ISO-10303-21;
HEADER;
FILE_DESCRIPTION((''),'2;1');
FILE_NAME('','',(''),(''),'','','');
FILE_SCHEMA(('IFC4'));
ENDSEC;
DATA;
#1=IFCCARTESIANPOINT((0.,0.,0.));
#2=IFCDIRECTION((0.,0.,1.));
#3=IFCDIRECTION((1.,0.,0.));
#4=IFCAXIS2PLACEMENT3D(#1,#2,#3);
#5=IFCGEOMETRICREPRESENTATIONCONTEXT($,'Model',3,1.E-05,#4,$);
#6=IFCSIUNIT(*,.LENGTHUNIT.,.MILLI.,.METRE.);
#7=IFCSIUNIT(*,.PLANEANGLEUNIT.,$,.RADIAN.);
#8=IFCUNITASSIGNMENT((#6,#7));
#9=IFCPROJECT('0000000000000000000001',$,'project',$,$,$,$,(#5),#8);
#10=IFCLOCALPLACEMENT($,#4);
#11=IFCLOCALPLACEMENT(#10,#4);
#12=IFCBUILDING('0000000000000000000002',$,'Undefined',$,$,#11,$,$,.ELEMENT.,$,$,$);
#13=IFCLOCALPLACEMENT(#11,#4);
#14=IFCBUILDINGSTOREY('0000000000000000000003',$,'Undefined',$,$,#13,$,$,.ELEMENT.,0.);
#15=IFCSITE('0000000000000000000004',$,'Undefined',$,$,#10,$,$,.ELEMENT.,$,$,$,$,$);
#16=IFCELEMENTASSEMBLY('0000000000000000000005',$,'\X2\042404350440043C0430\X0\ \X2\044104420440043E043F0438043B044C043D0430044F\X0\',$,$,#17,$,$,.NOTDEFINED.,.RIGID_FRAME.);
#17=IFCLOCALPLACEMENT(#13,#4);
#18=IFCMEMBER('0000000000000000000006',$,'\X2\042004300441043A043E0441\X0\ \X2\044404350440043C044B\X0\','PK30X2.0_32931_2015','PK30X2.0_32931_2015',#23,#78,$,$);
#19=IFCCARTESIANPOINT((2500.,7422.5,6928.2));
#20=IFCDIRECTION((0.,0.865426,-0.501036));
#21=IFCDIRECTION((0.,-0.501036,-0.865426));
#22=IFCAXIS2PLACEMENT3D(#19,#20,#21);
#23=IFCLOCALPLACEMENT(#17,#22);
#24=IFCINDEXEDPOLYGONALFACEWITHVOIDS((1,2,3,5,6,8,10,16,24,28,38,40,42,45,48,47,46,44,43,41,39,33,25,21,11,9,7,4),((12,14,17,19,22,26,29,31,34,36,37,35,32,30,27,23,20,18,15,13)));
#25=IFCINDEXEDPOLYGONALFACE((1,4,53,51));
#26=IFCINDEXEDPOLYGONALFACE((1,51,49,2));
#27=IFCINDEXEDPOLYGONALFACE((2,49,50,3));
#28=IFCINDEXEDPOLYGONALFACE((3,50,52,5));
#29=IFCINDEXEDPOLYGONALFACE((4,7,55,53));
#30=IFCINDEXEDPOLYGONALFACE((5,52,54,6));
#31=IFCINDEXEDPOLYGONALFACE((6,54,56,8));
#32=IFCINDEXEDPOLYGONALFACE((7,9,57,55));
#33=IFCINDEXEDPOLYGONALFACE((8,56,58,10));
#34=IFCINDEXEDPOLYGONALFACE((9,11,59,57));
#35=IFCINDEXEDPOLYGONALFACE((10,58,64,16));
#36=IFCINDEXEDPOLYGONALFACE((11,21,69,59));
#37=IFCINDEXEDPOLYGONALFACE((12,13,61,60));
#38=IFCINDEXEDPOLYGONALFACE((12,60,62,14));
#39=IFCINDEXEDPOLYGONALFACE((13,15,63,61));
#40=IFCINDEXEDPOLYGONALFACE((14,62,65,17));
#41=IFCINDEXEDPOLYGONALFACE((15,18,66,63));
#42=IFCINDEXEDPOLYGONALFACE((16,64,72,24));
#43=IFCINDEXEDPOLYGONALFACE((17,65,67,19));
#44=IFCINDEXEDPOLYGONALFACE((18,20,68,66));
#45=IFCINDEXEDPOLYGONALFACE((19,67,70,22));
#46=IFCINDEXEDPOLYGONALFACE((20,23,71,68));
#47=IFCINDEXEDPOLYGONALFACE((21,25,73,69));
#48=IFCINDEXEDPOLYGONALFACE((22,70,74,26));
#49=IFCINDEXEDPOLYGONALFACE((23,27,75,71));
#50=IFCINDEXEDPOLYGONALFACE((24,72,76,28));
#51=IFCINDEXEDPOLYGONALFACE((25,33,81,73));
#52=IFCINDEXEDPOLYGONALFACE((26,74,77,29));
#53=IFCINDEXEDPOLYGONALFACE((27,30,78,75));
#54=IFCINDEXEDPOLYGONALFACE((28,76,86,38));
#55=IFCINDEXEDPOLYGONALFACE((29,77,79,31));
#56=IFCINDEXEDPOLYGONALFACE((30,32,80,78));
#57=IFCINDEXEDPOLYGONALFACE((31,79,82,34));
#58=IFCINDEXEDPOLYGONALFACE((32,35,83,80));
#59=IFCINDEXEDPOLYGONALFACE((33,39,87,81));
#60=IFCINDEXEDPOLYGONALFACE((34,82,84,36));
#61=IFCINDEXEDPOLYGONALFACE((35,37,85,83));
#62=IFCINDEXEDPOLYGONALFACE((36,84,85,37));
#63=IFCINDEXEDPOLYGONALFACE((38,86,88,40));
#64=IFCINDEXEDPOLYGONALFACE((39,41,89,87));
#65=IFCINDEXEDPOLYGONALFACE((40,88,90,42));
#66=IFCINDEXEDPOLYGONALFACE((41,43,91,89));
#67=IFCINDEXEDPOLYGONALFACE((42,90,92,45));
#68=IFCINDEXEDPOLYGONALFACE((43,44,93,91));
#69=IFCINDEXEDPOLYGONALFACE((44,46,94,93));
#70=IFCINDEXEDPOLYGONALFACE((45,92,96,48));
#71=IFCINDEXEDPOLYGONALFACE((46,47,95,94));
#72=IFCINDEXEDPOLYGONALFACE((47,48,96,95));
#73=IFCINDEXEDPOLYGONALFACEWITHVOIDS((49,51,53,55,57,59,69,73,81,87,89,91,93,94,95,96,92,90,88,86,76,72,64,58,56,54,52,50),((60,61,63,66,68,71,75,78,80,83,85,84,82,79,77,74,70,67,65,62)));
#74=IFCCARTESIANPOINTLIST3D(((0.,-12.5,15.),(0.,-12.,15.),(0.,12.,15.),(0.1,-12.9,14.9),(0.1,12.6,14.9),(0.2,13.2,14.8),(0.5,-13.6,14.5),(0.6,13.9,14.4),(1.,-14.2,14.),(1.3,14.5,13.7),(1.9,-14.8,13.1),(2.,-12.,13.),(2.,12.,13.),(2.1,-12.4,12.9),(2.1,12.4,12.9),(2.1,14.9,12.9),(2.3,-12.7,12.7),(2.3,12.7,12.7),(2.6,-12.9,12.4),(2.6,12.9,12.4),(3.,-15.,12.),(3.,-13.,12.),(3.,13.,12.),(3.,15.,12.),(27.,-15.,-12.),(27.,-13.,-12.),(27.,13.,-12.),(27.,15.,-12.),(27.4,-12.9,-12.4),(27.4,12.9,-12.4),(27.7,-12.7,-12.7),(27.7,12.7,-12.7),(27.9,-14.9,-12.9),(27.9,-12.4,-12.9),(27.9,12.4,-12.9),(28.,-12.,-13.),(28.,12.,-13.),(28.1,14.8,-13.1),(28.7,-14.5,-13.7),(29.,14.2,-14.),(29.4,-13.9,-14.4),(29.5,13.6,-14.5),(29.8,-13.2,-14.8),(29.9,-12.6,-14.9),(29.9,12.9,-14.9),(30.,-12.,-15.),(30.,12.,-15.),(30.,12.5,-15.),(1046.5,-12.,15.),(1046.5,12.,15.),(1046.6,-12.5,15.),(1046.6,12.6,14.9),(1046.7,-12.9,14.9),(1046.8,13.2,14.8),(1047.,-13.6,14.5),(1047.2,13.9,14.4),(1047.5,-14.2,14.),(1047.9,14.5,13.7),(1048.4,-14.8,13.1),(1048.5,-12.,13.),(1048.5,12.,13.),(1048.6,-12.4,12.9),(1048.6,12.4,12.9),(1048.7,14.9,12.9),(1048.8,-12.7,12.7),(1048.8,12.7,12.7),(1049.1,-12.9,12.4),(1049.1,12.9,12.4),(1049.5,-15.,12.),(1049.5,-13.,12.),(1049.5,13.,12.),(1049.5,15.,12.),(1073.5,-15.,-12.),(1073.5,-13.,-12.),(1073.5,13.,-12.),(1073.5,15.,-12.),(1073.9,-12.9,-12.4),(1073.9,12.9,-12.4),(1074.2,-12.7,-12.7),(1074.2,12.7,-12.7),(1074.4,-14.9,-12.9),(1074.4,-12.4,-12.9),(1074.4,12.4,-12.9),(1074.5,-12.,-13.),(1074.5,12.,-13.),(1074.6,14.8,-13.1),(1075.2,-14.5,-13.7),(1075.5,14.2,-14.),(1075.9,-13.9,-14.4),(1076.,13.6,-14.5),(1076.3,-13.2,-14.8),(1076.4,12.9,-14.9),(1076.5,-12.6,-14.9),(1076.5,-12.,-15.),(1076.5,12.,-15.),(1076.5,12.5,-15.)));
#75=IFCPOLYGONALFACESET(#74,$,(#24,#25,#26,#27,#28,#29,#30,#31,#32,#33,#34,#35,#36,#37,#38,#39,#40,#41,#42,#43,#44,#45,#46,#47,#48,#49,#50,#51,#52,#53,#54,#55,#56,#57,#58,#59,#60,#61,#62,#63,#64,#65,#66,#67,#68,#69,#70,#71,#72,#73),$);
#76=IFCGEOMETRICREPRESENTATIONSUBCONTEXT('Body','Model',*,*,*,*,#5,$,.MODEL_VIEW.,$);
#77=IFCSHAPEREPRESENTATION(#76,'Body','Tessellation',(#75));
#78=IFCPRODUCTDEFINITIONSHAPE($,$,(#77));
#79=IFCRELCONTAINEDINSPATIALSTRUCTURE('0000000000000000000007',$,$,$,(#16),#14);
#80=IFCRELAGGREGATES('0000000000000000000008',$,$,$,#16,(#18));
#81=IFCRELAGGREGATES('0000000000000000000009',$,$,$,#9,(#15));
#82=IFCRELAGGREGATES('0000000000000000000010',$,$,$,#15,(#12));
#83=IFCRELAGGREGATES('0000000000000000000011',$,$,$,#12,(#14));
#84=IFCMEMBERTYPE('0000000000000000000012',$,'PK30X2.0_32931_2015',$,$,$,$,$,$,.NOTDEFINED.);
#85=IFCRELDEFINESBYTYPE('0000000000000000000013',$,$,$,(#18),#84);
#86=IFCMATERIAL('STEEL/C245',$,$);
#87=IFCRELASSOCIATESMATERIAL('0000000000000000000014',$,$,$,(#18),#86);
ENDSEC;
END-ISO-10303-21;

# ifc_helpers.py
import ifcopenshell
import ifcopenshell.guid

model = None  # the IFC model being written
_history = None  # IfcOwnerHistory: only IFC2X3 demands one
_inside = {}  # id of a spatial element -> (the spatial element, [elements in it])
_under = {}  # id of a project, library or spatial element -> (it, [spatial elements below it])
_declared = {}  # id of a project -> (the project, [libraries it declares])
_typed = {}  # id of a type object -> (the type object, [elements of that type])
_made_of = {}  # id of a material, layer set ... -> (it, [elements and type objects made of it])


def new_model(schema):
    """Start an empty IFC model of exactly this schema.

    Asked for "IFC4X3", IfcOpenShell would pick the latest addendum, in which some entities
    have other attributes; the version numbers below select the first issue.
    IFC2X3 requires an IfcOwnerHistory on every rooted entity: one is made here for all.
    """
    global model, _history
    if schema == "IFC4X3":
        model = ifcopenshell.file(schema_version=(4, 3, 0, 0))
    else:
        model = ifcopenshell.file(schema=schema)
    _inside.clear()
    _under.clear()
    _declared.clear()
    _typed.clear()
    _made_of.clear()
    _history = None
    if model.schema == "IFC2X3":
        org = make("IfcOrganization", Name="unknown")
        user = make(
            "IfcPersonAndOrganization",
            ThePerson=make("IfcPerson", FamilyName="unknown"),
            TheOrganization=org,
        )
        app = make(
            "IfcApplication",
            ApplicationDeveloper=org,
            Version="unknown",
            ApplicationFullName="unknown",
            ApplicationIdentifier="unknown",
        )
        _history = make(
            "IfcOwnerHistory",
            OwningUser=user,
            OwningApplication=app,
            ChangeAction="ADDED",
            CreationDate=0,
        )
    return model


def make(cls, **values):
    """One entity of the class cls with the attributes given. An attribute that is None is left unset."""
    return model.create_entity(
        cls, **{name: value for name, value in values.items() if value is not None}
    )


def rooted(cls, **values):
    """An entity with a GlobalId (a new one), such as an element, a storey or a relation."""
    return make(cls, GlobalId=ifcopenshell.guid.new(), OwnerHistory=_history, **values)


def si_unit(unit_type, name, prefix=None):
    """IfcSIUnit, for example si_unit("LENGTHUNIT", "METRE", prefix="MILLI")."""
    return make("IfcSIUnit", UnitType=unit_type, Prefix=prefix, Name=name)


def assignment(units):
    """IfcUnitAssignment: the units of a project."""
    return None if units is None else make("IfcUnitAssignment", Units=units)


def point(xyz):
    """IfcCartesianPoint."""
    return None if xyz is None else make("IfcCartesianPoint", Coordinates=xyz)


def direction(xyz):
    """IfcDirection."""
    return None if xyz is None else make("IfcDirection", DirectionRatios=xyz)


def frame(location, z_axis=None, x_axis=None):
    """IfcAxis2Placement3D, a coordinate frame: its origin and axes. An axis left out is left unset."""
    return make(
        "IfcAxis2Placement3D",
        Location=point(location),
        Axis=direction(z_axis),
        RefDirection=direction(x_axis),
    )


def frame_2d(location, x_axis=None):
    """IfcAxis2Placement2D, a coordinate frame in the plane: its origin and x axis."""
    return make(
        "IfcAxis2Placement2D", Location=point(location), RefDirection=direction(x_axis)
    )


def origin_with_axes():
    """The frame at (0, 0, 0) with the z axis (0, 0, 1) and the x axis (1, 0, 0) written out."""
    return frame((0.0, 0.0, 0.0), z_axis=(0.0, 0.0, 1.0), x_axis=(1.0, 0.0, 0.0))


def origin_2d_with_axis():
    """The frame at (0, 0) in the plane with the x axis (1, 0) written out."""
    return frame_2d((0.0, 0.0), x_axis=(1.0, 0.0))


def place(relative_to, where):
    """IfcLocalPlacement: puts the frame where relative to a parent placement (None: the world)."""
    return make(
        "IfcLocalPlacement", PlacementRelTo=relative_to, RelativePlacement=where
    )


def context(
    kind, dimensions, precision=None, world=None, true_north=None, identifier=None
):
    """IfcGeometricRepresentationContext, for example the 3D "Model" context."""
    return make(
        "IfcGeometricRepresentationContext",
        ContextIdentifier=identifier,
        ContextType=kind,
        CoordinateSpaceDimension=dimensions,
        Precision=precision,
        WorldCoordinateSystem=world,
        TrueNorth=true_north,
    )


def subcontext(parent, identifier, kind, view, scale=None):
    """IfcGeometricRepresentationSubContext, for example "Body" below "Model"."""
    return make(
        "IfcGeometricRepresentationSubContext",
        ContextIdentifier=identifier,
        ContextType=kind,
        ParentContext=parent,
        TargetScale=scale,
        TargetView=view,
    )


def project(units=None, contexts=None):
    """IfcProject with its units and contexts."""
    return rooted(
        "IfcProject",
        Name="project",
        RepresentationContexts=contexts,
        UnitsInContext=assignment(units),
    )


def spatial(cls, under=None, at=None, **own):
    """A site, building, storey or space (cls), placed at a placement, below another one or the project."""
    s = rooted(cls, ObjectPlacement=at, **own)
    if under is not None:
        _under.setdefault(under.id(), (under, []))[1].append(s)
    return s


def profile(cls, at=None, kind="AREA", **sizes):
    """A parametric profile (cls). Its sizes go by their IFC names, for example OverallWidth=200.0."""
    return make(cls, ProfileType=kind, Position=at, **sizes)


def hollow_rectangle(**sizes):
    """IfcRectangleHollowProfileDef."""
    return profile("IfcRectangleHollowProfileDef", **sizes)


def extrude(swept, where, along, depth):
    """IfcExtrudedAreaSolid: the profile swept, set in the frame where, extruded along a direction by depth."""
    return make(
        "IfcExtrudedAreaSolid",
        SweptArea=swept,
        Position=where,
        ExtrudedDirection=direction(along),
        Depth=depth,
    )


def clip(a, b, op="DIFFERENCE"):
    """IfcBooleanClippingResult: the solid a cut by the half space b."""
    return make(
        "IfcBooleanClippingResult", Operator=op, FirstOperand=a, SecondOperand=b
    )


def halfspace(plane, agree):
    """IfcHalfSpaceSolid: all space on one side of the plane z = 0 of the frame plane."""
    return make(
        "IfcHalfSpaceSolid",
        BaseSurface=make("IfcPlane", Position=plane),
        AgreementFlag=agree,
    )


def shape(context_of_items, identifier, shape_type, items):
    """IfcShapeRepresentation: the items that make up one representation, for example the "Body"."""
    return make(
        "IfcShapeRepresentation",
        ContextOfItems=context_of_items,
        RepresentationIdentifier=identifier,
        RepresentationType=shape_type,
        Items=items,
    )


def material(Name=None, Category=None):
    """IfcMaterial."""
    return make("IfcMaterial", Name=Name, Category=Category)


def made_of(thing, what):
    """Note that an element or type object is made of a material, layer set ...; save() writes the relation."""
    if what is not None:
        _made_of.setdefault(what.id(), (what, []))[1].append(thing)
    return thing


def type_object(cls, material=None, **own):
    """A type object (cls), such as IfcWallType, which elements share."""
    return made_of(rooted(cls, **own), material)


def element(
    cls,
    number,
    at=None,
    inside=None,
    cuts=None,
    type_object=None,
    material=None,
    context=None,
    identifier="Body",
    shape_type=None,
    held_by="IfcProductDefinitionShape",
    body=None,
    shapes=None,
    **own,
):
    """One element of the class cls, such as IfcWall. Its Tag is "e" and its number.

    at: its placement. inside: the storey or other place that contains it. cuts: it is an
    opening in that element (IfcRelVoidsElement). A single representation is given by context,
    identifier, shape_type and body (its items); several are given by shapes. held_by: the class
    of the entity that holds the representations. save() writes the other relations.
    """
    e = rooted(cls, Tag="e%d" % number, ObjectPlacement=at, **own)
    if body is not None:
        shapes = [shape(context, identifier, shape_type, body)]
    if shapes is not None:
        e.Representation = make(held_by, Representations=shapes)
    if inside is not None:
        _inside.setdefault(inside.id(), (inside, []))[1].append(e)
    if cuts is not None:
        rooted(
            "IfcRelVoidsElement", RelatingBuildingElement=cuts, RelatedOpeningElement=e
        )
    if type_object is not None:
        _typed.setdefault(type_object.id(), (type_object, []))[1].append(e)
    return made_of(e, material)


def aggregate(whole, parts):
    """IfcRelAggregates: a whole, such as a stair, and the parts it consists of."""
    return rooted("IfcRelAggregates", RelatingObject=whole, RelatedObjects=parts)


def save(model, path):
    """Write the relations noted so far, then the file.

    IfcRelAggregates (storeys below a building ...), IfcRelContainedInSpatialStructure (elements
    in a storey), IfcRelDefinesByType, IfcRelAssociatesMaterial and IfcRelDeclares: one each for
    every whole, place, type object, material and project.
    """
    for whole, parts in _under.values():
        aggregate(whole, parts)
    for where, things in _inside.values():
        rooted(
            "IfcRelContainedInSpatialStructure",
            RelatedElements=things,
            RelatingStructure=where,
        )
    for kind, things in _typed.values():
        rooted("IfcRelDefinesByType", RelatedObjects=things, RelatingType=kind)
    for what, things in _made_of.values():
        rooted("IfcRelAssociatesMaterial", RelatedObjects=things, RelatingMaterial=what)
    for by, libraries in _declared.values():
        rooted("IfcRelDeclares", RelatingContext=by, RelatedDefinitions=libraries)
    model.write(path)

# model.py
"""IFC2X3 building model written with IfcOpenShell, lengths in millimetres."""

from ifc_helpers import new_model, si_unit, frame, origin_with_axes, origin_2d_with_axis, place, context, subcontext, project, spatial, hollow_rectangle, extrude, clip, halfspace, material, type_object, element, aggregate, save


model = new_model("IFC2X3")

# Units and contexts
model_context = context("Model", 3, precision=1e-05, world=origin_with_axes())
body_context = subcontext(model_context, "Body", "Model", "MODEL_VIEW")
ifc_project = project(units=[si_unit("LENGTHUNIT", "METRE", prefix="MILLI"), si_unit("PLANEANGLEUNIT", "RADIAN")], contexts=[model_context])

# Site, building, storey
site_placement = place(None, origin_with_axes())
site = spatial("IfcSite", under=ifc_project, at=site_placement, Name="Undefined", CompositionType="ELEMENT")
building_placement = place(site_placement, origin_with_axes())
building = spatial("IfcBuilding", under=site, at=building_placement, Name="Undefined", CompositionType="ELEMENT")
storey_placement = place(building_placement, origin_with_axes())
storey = spatial("IfcBuildingStorey", under=building, at=storey_placement, Name="Undefined", CompositionType="ELEMENT", Elevation=0.0)

# Element assembly
ifc_material_1 = material(Name="STEEL/C245")
assembly_1_placement = place(storey_placement, origin_with_axes())
assembly_1 = element("IfcElementAssembly", 1, at=assembly_1_placement, inside=storey, Name="Ферма стропильная", AssemblyPlace="NOTDEFINED", PredefinedType="RIGID_FRAME")

# Member
member_type = type_object("IfcMemberType", Name="PK30X2.0_32931_2015", PredefinedType="NOTDEFINED")
member_1_placement = place(assembly_1_placement, frame((2500.0, 7422.5, 6928.2), z_axis=(0.0, 0.865426, -0.501036), x_axis=(0.0, -0.501036, -0.865426)))
member_1 = element("IfcMember", 2, at=member_1_placement, type_object=member_type, material=ifc_material_1, Name="Раскос фермы", Description="PK30X2.0_32931_2015", ObjectType="PK30X2.0_32931_2015", context=body_context, shape_type="Clipping", body=[
    clip(clip(extrude(hollow_rectangle(XDim=30.0, YDim=30.0, WallThickness=2.0, InnerFilletRadius=1.0, OuterFilletRadius=3.0, at=origin_2d_with_axis()), frame((1091.8, 0.0, 0.0), z_axis=(-1.0, 0.0, 0.0), x_axis=(0.0, -1.0, 0.0)), (0.0, 0.0, 1.0), 1107.1), halfspace(frame((1060.0, 0.0, 1.5), z_axis=(-0.707107, 0.0, -0.707107), x_axis=(0.0, -1.0, 0.0)), True)), halfspace(frame((34.5, 0.0, -19.5), z_axis=(-0.707107, 0.0, -0.707107), x_axis=(0.0, -1.0, 0.0)), False)),
])
aggregate(assembly_1, [member_1])

save(model, "model.ifc")
